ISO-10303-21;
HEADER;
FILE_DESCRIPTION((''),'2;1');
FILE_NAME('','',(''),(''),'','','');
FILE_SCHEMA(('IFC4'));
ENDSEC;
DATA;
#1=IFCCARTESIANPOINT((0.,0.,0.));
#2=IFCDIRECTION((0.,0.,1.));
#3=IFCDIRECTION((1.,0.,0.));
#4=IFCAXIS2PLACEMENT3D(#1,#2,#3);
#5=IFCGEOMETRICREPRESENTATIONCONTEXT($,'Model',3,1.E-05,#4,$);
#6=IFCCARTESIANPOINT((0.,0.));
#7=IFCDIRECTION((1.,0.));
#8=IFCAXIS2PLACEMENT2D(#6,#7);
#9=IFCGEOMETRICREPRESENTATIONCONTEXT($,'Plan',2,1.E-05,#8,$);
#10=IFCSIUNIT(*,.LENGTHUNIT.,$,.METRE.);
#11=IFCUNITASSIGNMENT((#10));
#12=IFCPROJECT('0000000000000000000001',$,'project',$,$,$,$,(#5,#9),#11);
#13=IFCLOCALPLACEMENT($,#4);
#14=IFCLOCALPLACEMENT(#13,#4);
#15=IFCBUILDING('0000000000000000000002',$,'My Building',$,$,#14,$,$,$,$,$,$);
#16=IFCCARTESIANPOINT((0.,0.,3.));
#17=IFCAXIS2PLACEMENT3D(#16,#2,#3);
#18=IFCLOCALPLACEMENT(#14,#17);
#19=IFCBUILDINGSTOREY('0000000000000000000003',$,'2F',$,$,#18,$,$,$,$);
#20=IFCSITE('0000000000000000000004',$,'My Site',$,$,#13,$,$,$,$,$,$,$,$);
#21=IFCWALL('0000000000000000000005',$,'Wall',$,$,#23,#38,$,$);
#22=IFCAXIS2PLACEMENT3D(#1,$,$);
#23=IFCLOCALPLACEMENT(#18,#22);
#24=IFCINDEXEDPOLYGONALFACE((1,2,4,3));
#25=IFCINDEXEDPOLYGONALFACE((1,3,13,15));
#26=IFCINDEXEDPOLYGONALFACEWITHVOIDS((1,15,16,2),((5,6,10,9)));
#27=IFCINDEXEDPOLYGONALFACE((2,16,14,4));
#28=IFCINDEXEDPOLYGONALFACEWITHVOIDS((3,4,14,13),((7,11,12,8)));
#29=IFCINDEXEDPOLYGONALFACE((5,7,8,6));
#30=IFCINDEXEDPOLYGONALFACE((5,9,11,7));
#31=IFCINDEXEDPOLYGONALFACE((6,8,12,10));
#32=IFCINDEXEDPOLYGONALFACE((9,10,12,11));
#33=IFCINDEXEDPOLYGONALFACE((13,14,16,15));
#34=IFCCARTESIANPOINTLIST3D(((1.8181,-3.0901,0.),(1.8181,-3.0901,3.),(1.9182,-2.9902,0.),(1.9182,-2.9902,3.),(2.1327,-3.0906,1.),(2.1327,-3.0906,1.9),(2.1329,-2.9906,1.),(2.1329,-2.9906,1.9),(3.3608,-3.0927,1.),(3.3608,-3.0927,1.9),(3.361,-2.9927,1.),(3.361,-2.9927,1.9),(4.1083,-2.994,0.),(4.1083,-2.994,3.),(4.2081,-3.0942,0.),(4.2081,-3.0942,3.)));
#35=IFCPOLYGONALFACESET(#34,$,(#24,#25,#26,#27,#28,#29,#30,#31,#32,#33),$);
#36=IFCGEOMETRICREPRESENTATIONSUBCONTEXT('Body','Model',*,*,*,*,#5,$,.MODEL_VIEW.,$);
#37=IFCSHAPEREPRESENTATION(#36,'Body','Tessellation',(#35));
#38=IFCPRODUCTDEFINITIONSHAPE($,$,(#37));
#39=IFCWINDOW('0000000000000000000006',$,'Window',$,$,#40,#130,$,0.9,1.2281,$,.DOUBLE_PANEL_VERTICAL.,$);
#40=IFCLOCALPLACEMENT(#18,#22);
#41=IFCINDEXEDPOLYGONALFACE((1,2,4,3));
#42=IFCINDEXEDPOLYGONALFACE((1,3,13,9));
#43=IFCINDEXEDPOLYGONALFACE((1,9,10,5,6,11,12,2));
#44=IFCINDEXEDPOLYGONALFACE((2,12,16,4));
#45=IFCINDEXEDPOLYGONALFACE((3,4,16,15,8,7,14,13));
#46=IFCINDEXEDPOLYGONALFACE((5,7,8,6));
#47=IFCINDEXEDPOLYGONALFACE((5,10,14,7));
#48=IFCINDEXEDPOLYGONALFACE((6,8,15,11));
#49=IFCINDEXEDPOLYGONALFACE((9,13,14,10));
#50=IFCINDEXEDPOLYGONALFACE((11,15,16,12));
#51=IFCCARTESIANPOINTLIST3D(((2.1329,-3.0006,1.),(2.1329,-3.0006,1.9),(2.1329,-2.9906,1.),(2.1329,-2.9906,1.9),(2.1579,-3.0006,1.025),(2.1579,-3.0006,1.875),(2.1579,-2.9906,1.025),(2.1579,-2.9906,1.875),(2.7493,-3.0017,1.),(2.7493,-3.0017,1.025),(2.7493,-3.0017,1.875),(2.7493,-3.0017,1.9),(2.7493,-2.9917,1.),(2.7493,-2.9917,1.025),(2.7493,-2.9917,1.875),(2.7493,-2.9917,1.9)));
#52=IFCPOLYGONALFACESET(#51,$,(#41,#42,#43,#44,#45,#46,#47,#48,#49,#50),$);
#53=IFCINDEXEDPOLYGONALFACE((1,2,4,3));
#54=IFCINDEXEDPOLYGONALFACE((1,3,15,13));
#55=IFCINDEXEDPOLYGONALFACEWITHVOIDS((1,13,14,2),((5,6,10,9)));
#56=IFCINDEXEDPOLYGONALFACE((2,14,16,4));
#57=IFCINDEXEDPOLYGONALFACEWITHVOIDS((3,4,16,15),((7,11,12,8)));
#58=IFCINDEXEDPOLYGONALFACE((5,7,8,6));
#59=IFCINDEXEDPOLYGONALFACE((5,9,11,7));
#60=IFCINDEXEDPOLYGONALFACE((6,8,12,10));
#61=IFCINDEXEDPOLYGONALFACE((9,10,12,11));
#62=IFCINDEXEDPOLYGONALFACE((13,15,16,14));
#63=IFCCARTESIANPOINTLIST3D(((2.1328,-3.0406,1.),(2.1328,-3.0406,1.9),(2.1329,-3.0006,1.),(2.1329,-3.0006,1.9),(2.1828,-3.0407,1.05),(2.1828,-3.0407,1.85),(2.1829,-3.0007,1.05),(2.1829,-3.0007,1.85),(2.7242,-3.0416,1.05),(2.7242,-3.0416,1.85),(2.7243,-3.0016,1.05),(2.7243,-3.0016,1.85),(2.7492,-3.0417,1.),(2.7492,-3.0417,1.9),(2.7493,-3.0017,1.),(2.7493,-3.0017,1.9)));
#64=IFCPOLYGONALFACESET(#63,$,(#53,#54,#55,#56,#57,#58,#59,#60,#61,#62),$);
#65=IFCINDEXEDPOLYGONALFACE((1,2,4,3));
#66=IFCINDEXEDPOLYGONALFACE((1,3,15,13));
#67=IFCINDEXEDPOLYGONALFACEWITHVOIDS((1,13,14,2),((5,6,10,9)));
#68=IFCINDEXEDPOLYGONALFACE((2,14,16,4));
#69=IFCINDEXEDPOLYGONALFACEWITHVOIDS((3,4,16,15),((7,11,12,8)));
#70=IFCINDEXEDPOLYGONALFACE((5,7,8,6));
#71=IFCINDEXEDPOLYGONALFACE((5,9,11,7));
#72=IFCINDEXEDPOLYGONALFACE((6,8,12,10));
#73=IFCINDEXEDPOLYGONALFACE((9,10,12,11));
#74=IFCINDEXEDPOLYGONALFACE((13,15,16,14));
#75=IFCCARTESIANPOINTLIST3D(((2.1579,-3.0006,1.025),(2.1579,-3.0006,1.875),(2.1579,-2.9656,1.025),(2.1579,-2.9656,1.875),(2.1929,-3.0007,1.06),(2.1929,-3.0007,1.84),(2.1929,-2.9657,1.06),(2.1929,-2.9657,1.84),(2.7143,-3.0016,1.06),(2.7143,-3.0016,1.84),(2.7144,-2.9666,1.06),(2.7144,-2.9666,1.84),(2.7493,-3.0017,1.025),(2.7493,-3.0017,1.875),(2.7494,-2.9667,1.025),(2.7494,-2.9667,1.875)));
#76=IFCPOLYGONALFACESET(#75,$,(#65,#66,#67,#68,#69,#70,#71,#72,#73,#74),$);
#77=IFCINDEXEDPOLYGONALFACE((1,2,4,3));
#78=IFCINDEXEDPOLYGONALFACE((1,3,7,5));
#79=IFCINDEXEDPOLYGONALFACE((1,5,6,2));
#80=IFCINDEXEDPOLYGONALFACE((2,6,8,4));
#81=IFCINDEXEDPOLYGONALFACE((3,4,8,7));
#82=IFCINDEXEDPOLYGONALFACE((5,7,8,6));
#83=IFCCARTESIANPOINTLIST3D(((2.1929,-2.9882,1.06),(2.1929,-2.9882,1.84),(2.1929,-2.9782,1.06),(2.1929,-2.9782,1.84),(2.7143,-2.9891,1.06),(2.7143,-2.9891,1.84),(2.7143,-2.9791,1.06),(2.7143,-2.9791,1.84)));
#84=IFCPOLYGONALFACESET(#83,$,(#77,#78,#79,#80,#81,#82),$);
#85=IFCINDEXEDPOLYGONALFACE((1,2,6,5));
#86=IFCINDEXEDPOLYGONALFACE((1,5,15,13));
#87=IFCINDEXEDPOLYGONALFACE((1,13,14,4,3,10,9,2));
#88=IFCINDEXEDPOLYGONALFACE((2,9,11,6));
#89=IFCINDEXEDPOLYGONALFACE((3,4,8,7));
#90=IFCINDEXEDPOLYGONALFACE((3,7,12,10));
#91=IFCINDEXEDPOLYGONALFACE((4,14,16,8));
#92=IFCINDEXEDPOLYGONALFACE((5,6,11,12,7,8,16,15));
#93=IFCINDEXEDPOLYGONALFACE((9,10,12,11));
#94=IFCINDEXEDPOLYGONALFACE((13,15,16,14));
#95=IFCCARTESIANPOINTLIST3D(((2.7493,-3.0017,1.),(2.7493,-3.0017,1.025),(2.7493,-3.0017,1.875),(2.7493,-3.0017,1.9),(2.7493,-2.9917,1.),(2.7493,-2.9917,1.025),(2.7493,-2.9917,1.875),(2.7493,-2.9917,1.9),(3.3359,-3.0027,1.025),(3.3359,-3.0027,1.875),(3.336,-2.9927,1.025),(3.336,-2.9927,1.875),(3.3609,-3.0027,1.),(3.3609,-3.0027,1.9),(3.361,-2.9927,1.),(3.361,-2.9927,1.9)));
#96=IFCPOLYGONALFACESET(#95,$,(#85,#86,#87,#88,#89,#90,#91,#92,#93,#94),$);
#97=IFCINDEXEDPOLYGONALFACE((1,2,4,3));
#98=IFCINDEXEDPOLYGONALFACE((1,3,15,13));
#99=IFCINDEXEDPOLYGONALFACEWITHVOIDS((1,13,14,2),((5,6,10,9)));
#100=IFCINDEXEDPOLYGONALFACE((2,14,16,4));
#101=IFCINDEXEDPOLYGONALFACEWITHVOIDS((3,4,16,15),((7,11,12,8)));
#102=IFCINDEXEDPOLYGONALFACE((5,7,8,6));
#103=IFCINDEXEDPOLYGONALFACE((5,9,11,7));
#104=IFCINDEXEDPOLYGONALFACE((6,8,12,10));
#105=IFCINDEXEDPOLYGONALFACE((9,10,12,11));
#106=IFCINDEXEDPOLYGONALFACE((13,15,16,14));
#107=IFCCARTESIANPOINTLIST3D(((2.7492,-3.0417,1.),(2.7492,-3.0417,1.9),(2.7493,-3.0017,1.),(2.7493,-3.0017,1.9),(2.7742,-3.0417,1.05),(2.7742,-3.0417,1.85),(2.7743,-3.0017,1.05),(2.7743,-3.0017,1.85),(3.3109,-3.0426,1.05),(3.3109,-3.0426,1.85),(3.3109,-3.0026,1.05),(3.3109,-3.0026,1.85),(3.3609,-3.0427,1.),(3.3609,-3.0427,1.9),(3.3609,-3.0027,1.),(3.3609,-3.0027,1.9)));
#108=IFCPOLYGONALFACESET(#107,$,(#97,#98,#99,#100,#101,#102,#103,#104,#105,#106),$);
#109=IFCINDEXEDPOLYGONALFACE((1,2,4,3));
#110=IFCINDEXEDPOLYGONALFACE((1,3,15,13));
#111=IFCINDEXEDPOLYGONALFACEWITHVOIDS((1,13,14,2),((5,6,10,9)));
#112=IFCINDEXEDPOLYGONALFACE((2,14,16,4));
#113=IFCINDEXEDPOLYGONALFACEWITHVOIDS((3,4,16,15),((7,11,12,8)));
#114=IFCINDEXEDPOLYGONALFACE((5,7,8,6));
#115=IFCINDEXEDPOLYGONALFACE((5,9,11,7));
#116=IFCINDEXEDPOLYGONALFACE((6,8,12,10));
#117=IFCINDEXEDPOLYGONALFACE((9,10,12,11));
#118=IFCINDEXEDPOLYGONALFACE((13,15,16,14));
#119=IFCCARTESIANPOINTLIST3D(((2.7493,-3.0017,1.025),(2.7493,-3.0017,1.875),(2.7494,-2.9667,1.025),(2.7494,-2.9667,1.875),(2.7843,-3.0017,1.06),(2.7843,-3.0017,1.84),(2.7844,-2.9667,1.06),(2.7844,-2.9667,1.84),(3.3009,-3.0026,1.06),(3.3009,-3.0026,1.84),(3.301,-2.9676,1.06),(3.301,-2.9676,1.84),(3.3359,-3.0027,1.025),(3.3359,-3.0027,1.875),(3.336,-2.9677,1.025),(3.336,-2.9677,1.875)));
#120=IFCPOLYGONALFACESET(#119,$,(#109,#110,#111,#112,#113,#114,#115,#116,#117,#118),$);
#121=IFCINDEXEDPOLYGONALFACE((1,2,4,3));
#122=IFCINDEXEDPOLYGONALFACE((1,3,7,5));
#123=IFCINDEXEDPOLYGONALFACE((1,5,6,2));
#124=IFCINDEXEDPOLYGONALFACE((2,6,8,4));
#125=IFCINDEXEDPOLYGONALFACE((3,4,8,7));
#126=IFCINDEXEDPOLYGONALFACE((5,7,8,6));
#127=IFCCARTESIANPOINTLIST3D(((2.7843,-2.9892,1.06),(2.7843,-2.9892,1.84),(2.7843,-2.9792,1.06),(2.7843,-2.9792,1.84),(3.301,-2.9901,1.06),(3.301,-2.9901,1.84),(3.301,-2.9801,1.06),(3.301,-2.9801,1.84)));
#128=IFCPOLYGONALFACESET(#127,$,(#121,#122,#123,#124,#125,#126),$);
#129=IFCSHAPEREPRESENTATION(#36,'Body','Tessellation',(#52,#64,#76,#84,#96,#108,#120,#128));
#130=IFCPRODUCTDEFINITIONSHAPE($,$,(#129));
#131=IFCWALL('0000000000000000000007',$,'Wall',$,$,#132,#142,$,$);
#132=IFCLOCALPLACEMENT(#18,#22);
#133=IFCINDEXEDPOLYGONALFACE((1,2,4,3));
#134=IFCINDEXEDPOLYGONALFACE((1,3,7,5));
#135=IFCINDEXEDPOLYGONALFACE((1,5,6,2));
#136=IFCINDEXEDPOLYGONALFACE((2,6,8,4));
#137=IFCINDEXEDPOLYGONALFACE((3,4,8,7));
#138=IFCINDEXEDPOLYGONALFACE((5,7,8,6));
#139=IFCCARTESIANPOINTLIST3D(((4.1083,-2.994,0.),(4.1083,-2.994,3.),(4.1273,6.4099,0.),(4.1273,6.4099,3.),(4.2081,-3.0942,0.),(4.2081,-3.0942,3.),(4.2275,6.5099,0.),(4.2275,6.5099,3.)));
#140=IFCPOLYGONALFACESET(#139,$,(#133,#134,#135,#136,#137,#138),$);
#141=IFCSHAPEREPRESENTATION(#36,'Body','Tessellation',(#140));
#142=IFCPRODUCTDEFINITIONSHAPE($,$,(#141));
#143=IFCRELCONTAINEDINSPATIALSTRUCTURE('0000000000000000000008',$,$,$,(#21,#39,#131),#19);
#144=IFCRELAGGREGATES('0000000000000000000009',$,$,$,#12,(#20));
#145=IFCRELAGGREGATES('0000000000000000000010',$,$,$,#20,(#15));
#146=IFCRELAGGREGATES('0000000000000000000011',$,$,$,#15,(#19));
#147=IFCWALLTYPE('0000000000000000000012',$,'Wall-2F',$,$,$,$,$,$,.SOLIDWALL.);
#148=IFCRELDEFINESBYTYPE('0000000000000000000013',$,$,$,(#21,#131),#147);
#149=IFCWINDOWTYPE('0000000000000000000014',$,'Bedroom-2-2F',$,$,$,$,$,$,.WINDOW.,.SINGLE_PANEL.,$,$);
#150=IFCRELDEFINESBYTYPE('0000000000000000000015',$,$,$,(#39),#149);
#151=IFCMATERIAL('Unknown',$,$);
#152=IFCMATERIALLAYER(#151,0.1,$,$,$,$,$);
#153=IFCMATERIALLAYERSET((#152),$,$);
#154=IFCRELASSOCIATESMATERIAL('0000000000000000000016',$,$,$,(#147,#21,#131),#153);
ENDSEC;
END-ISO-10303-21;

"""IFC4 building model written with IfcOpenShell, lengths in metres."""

from ifc_helpers import new_model, entity, si_unit, frame, origin_with_axes, origin_2d_with_axis, place, context, subcontext, project, spatial, line, indexed_curve, outline, extrude, shape, source, transform, mapped, material, layer, layer_set, layer_usage, type_object, type_shapes, element, fill, save


model = new_model("IFC4")

# Units and contexts
model_context = context("Model", 3, precision=1e-05, world=origin_with_axes())
plan_context = context("Plan", 2, precision=1e-05, world=origin_2d_with_axis())
body_context_1 = subcontext(model_context, "Body", "Model", "MODEL_VIEW")
body_context_2 = subcontext(plan_context, "Body", "Plan", "PLAN_VIEW")
ifc_project = project(units=[si_unit("LENGTHUNIT", "METRE")], contexts=[model_context, plan_context])

# Site, building, storey
site_placement = place(None, origin_with_axes())
site = spatial("IfcSite", under=ifc_project, at=site_placement, Name="My Site")
building_placement = place(site_placement, origin_with_axes())
building = spatial("IfcBuilding", under=site, at=building_placement, Name="My Building")
storey_placement = place(building_placement, frame((0.0, 0.0, 3.0), z_axis=(0.0, 0.0, 1.0), x_axis=(1.0, 0.0, 0.0)))
storey = spatial("IfcBuildingStorey", under=building, at=storey_placement, Name="2F")

# Shared definitions
ifc_material = material(Name="Unknown")

# Shared definitions
ifc_layer_1 = layer(ifc_material, 0.1)
ifc_layer_set_1 = layer_set([ifc_layer_1])
wall_type = type_object("IfcWallType", Name="Wall-2F", PredefinedType="SOLIDWALL", material=ifc_layer_set_1)

# Wall, opening, window
ifc_layer_usage_1 = layer_usage(ifc_layer_set_1, "AXIS2", "POSITIVE", 0.0)
wall_1_placement = place(storey_placement, frame((1.8181, -3.0901, 0.0), z_axis=(0.0, 0.0, 1.0), x_axis=(0.999999, -0.001718, 0.0)))
wall_1 = element("IfcWall", 1, at=wall_1_placement, inside=storey, type_object=wall_type, material=ifc_layer_usage_1, Name="Wall", context=body_context_1, shape_type="SweptSolid", body=[
    extrude(outline(indexed_curve([(0.0, 0.0), (0.1, 0.1), (2.29, 0.1), (2.39, 0.0)], segments=[line(1, 2, 3, 4, 1)])), origin_with_axes(), (0.0, 0.0, 1.0), 3.0),
])
shared_shape_1 = source(origin_with_axes(), body_context_1, "Body", "SweptSolid", [
    extrude(outline(indexed_curve([(0.0, 0.0), (1.2281, 0.0), (1.2281, 0.9), (0.0, 0.9)], segments=[line(1, 2, 3, 4, 1)])), frame((0.0, -0.6, 0.0), z_axis=(0.0, -1.0, 0.0), x_axis=(1.0, 0.0, 0.0)), (0.0, 0.0, -1.0), 1.2),
])
opening_1_placement = place(wall_1_placement, frame((0.3146, 0.0, 1.0), z_axis=(0.0, 0.0, 1.0), x_axis=(1.0, -0.000001, 0.0)))
opening_1 = element("IfcOpeningElement", 2, at=opening_1_placement, cuts=wall_1, PredefinedType="OPENING", context=body_context_1, shape_type="MappedRepresentation", body=[
    mapped(shared_shape_1, transform((0.0, 0.0, 0.0), x_axis=(1.0, 0.0, 0.0), y_axis=(0.0, 1.0, 0.0), z_axis=(0.0, 0.0, 1.0), scale=1.0)),
])
window_type_1 = type_object("IfcWindowType", Name="Bedroom-2-2F", PartitioningType="SINGLE_PANEL", PredefinedType="WINDOW")
shared_shape_2 = source(origin_with_axes(), body_context_1, "Body", "SweptSolid", [
    extrude(outline(indexed_curve([(0.6164, 0.0), (0.0, 0.0), (0.0, 0.9), (0.6164, 0.9), (0.6164, 0.875), (0.025, 0.875), (0.025, 0.025), (0.6164, 0.025)], segments=[line(1, 2, 3, 4, 5, 6, 7, 8, 1)])), frame((0.0, 0.09, 0.0), z_axis=(0.0, -1.0, 0.0), x_axis=(1.0, 0.0, 0.0)), (0.0, 0.0, -1.0), 0.01),
    extrude(outline(indexed_curve([(0.0, 0.0), (0.6164, 0.0), (0.6164, 0.9), (0.0, 0.9)], segments=[line(1, 2, 3, 4, 1)]), holes=[indexed_curve([(0.05, 0.05), (0.5914, 0.05), (0.5914, 0.85), (0.05, 0.85)], segments=[line(1, 2, 3, 4, 1)])]), frame((0.0, 0.05, 0.0), z_axis=(0.0, -1.0, 0.0), x_axis=(1.0, 0.0, 0.0)), (0.0, 0.0, -1.0), 0.04),
    extrude(outline(indexed_curve([(0.0, 0.0), (0.5914, 0.0), (0.5914, 0.85), (0.0, 0.85)], segments=[line(1, 2, 3, 4, 1)]), holes=[indexed_curve([(0.035, 0.035), (0.5564, 0.035), (0.5564, 0.815), (0.035, 0.815)], segments=[line(1, 2, 3, 4, 1)])]), frame((0.025, 0.09, 0.025), z_axis=(0.0, -1.0, 0.0), x_axis=(1.0, 0.0, 0.0)), (0.0, 0.0, -1.0), 0.035),
    extrude(outline(indexed_curve([(0.035, 0.035), (0.5564, 0.035), (0.5564, 0.815), (0.035, 0.815)], segments=[line(1, 2, 3, 4, 1)])), frame((0.025, 0.1025, 0.025), z_axis=(0.0, -1.0, 0.0), x_axis=(1.0, 0.0, 0.0)), (0.0, 0.0, -1.0), 0.01),
    extrude(outline(indexed_curve([(0.0, 0.9), (0.6116, 0.9), (0.6116, 0.0), (0.0, 0.0), (0.0, 0.025), (0.5866, 0.025), (0.5866, 0.875), (0.0, 0.875)], segments=[line(1, 2, 3, 4, 5, 6, 7, 8, 1)])), frame((0.6164, 0.09, 0.0), z_axis=(0.0, -1.0, 0.0), x_axis=(1.0, 0.0, 0.0)), (0.0, 0.0, -1.0), 0.01),
    extrude(outline(indexed_curve([(0.0, 0.0), (0.6116, 0.0), (0.6116, 0.9), (0.0, 0.9)], segments=[line(1, 2, 3, 4, 1)]), holes=[indexed_curve([(0.025, 0.05), (0.5616, 0.05), (0.5616, 0.85), (0.025, 0.85)], segments=[line(1, 2, 3, 4, 1)])]), frame((0.6164, 0.05, 0.0), z_axis=(0.0, -1.0, 0.0), x_axis=(1.0, 0.0, 0.0)), (0.0, 0.0, -1.0), 0.04),
    extrude(outline(indexed_curve([(0.0, 0.0), (0.5866, 0.0), (0.5866, 0.85), (0.0, 0.85)], segments=[line(1, 2, 3, 4, 1)]), holes=[indexed_curve([(0.035, 0.035), (0.5516, 0.035), (0.5516, 0.815), (0.035, 0.815)], segments=[line(1, 2, 3, 4, 1)])]), frame((0.6164, 0.09, 0.025), z_axis=(0.0, -1.0, 0.0), x_axis=(1.0, 0.0, 0.0)), (0.0, 0.0, -1.0), 0.035),
    extrude(outline(indexed_curve([(0.035, 0.035), (0.5516, 0.035), (0.5516, 0.815), (0.035, 0.815)], segments=[line(1, 2, 3, 4, 1)])), frame((0.6164, 0.1025, 0.025), z_axis=(0.0, -1.0, 0.0), x_axis=(1.0, 0.0, 0.0)), (0.0, 0.0, -1.0), 0.01),
])
shared_shape_3 = source(origin_with_axes(), body_context_2, "Body", "Curve2D", [
    entity("IfcIndexedPolyCurve", entity("IfcCartesianPointList2D", [[0.05, 0.05], [0.5914, 0.05]])),
    entity("IfcIndexedPolyCurve", entity("IfcCartesianPointList2D", [[0.0, 0.1], [0.025, 0.1], [0.025, 0.09], [0.05, 0.09], [0.05, 0.05], [0.0, 0.05]]), [entity("IfcLineIndex", [1, 2, 3, 4, 5, 6, 1])]),
    entity("IfcIndexedPolyCurve", entity("IfcCartesianPointList2D", [[0.6164, 0.1], [0.6164, 0.1], [0.6164, 0.09], [0.5914, 0.09], [0.5914, 0.05], [0.6164, 0.05]])),
    entity("IfcIndexedPolyCurve", entity("IfcCartesianPointList2D", [[0.025, 0.09], [0.06, 0.09], [0.06, 0.125], [0.025, 0.125]]), [entity("IfcLineIndex", [1, 2, 3, 4, 1])]),
    entity("IfcIndexedPolyCurve", entity("IfcCartesianPointList2D", [[0.6164, 0.09], [0.5814, 0.09], [0.5814, 0.125], [0.6164, 0.125]]), [entity("IfcLineIndex", [1, 2, 3, 4, 1])]),
    entity("IfcIndexedPolyCurve", entity("IfcCartesianPointList2D", [[0.06, 0.09], [0.5814, 0.09]])),
    entity("IfcIndexedPolyCurve", entity("IfcCartesianPointList2D", [[0.06, 0.125], [0.5814, 0.125]])),
    entity("IfcIndexedPolyCurve", entity("IfcCartesianPointList2D", [[0.06, 0.1075], [0.5814, 0.1075]])),
    entity("IfcIndexedPolyCurve", entity("IfcCartesianPointList2D", [[0.6414, 0.05], [1.1781, 0.05]])),
    entity("IfcIndexedPolyCurve", entity("IfcCartesianPointList2D", [[0.6164, 0.1], [0.6164, 0.1], [0.6164, 0.09], [0.6414, 0.09], [0.6414, 0.05], [0.6164, 0.05]])),
    entity("IfcIndexedPolyCurve", entity("IfcCartesianPointList2D", [[1.2281, 0.1], [1.2031, 0.1], [1.2031, 0.09], [1.1781, 0.09], [1.1781, 0.05], [1.2281, 0.05]]), [entity("IfcLineIndex", [1, 2, 3, 4, 5, 6, 1])]),
    entity("IfcIndexedPolyCurve", entity("IfcCartesianPointList2D", [[0.6164, 0.09], [0.6514, 0.09], [0.6514, 0.125], [0.6164, 0.125]]), [entity("IfcLineIndex", [1, 2, 3, 4, 1])]),
    entity("IfcIndexedPolyCurve", entity("IfcCartesianPointList2D", [[1.2031, 0.09], [1.1681, 0.09], [1.1681, 0.125], [1.2031, 0.125]]), [entity("IfcLineIndex", [1, 2, 3, 4, 1])]),
    entity("IfcIndexedPolyCurve", entity("IfcCartesianPointList2D", [[0.6514, 0.09], [1.1681, 0.09]])),
    entity("IfcIndexedPolyCurve", entity("IfcCartesianPointList2D", [[0.6514, 0.125], [1.1681, 0.125]])),
    entity("IfcIndexedPolyCurve", entity("IfcCartesianPointList2D", [[0.6514, 0.1075], [1.1681, 0.1075]])),
])
type_shapes(window_type_1, [shared_shape_2, shared_shape_3])
window_1_placement = place(opening_1_placement, frame((0.0, 0.0, 0.0), z_axis=(0.0, 0.0, 1.0), x_axis=(1.0, 0.0, 0.0)))
window_1 = element("IfcWindow", 3, at=window_1_placement, inside=storey, type_object=window_type_1, Name="Window", OverallHeight=0.9, OverallWidth=1.2281, PartitioningType="DOUBLE_PANEL_VERTICAL", shapes=[
    shape(body_context_1, "Body", "MappedRepresentation", [mapped(shared_shape_2, transform((0.0, 0.0, 0.0), x_axis=(1.0, 0.0, 0.0), y_axis=(0.0, 1.0, 0.0), z_axis=(0.0, 0.0, 1.0), scale=1.0))]),
    shape(body_context_2, "Body", "MappedRepresentation", [mapped(shared_shape_3, transform((0.0, 0.0, 0.0), x_axis=(1.0, 0.0, 0.0), y_axis=(0.0, 1.0, 0.0), z_axis=(0.0, 0.0, 1.0), scale=1.0))]),
])
fill(opening_1, window_1)

# Wall
ifc_layer_usage_2 = layer_usage(ifc_layer_set_1, "AXIS2", "POSITIVE", 0.0)
wall_2_placement = place(storey_placement, frame((4.2081, -3.0942, 0.0), z_axis=(0.0, 0.0, 1.0), x_axis=(0.002021, 0.999998, 0.0)))
element("IfcWall", 4, at=wall_2_placement, inside=storey, type_object=wall_type, material=ifc_layer_usage_2, Name="Wall", context=body_context_1, shape_type="SweptSolid", body=[
    extrude(outline(indexed_curve([(0.0, 0.0), (0.1, 0.1), (9.5039, 0.1), (9.6041, 0.0)], segments=[line(1, 2, 3, 4, 1)])), origin_with_axes(), (0.0, 0.0, 1.0), 3.0),
])

save(model, "model.ifc")
